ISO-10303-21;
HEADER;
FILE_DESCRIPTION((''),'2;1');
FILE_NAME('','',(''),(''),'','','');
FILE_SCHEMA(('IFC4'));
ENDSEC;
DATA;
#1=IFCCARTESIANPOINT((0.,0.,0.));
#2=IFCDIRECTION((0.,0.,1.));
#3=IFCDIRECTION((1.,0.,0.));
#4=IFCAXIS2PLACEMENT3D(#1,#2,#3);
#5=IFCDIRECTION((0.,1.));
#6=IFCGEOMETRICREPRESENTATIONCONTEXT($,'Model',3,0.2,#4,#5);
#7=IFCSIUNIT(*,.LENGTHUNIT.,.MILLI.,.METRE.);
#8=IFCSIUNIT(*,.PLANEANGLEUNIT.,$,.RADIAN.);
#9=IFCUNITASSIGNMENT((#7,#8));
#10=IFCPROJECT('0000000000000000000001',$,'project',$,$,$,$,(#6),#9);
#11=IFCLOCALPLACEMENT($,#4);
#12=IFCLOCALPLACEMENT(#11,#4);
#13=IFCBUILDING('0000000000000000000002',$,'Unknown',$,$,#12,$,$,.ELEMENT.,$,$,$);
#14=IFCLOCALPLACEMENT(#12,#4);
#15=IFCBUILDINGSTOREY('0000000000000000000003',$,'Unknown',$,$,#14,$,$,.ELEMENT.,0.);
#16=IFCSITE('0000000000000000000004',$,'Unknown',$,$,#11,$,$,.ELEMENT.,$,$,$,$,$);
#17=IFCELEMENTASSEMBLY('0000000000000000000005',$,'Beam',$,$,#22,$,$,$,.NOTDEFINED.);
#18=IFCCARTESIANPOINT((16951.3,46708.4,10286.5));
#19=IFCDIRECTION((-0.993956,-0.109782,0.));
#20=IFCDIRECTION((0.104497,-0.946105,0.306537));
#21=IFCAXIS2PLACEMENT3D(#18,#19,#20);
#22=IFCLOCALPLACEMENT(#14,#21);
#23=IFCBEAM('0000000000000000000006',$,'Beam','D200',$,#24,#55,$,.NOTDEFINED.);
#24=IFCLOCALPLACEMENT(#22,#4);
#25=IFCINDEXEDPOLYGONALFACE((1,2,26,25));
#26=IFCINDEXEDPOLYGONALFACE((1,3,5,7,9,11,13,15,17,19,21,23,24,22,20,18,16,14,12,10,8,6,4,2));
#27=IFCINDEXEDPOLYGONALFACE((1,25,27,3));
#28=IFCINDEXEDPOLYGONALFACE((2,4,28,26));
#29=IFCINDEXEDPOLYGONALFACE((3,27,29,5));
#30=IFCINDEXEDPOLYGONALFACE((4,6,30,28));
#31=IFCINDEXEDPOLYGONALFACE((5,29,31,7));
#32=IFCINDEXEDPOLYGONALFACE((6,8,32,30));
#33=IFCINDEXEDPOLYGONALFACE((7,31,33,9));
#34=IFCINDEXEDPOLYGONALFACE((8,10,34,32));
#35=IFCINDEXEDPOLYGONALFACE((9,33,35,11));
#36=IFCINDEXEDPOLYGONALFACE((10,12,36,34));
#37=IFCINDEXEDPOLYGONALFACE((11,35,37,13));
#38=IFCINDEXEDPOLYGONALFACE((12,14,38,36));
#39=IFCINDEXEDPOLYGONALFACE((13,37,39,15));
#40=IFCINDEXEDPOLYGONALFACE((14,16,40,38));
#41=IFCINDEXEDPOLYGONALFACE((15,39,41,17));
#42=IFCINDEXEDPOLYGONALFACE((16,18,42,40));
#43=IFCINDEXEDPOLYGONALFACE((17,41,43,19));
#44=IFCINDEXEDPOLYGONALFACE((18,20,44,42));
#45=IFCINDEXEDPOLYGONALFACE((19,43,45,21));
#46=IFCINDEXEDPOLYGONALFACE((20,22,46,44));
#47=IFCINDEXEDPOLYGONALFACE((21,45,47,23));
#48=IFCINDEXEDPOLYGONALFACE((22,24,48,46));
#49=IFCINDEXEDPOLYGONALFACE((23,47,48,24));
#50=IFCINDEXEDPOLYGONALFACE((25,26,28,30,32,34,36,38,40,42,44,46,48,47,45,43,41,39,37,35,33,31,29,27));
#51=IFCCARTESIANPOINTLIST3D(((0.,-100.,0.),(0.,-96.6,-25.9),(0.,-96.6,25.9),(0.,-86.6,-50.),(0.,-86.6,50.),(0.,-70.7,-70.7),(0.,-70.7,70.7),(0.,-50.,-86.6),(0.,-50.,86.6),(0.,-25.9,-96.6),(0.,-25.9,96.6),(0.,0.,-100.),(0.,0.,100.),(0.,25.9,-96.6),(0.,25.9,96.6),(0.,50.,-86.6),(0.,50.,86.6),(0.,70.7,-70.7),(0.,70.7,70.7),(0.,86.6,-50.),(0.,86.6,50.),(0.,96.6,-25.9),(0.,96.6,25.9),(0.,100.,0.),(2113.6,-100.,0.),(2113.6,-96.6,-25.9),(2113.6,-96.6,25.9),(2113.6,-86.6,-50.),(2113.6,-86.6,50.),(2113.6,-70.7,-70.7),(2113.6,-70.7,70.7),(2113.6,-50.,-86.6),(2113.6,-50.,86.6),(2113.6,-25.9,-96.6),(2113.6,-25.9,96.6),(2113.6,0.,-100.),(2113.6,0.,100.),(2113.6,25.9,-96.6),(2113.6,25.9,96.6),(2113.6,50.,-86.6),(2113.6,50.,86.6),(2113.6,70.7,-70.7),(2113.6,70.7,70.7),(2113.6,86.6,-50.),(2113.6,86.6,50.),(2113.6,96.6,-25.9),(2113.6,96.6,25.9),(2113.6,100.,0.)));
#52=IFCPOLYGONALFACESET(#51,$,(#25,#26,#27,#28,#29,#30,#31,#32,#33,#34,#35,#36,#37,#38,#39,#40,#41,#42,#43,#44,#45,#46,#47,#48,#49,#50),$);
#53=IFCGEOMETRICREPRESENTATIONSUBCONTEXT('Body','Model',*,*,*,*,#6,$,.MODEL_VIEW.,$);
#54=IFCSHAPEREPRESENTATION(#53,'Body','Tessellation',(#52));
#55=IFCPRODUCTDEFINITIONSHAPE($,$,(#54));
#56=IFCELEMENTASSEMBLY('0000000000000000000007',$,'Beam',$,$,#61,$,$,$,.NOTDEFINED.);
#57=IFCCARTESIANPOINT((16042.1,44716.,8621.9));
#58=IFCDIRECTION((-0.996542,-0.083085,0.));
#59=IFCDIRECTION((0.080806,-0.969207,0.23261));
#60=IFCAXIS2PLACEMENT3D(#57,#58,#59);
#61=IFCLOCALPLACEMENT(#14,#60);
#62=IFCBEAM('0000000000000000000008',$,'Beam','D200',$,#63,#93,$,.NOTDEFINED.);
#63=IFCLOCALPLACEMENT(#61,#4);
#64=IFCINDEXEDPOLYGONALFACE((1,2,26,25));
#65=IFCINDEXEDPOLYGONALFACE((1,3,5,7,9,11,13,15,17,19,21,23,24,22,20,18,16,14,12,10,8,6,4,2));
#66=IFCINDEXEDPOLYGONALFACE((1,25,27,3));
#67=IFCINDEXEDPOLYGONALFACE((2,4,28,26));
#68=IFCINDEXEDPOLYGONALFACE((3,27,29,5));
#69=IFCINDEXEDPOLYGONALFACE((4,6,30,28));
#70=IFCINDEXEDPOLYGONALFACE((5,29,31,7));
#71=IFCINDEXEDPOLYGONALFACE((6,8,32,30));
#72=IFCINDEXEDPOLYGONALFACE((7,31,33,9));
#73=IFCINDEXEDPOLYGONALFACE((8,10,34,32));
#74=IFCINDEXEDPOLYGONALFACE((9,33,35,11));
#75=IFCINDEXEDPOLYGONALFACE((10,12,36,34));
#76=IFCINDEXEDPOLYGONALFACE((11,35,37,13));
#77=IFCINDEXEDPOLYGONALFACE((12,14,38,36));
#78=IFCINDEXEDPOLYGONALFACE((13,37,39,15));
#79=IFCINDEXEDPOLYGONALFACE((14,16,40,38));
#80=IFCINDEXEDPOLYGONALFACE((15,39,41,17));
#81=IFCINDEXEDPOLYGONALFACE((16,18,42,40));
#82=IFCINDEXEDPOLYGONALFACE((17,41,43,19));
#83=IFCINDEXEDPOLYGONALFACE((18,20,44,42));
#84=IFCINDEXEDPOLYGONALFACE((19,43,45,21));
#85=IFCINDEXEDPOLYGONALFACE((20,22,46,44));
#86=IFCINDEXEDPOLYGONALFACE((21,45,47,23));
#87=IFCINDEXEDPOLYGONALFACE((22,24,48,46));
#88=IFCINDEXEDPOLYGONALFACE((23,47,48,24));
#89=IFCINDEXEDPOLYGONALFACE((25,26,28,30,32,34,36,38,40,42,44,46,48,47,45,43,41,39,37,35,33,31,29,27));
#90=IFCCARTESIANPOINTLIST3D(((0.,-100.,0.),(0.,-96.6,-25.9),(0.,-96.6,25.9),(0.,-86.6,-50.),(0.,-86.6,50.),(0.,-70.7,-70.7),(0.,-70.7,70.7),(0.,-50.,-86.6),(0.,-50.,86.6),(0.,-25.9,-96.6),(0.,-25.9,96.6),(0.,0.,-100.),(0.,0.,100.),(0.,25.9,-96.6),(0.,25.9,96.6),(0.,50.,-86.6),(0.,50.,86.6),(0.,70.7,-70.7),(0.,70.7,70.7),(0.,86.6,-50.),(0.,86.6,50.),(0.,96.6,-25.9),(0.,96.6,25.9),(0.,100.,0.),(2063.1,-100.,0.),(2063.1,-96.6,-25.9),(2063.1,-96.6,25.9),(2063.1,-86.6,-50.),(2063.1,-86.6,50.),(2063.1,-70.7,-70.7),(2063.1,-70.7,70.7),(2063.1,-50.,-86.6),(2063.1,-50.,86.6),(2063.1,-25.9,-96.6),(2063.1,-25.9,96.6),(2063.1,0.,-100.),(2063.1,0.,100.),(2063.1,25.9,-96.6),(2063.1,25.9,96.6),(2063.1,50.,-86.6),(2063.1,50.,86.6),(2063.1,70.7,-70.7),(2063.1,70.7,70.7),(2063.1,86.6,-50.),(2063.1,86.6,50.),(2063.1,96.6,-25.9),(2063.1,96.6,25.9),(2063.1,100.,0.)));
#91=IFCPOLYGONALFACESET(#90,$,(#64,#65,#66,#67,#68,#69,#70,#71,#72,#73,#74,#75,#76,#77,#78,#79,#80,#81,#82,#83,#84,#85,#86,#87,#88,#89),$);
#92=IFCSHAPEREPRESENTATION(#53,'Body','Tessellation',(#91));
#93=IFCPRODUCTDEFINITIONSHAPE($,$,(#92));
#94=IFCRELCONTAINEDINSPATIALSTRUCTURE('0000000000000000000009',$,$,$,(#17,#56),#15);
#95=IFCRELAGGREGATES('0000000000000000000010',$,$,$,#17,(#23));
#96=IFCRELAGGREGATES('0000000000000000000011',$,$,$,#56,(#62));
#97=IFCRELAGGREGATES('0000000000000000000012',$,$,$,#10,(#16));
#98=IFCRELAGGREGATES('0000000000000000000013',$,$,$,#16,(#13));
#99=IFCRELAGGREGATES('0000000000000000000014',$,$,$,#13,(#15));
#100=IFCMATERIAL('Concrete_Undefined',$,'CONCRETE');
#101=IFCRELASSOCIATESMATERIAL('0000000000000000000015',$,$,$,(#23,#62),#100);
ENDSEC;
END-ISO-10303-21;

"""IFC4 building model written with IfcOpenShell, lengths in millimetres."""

from ifc_helpers import new_model, si_unit, direction, frame, origin_with_axes, place, context, subcontext, project, spatial, line, indexed_curve, outline, extrude, material, element, aggregate, save


model = new_model("IFC4")

# Units and contexts
model_context = context("Model", 3, precision=0.2, world=origin_with_axes(), true_north=direction((0.0, 1.0)))
body_context = subcontext(model_context, "Body", "Model", "MODEL_VIEW")
ifc_project = project(units=[si_unit("LENGTHUNIT", "METRE", prefix="MILLI"), si_unit("PLANEANGLEUNIT", "RADIAN")], contexts=[model_context])

# Site, building, storey
site_placement = place(None, origin_with_axes())
site = spatial("IfcSite", under=ifc_project, at=site_placement, Name="Unknown", CompositionType="ELEMENT")
building_placement = place(site_placement, origin_with_axes())
building = spatial("IfcBuilding", under=site, at=building_placement, Name="Unknown", CompositionType="ELEMENT")
storey_placement = place(building_placement, origin_with_axes())
storey = spatial("IfcBuildingStorey", under=building, at=storey_placement, Name="Unknown", CompositionType="ELEMENT", Elevation=0.0)

# Shared definitions
ifc_material = material(Name="Concrete_Undefined", Category="CONCRETE")

# Element assembly, beam
assembly_1_placement = place(storey_placement, frame((16951.3, 46708.4, 10286.5), z_axis=(-0.993956, -0.109782, 0.0), x_axis=(0.104497, -0.946105, 0.306537)))
assembly_1 = element("IfcElementAssembly", 1, at=assembly_1_placement, inside=storey, Name="Beam", PredefinedType="NOTDEFINED")
beam_1_placement = place(assembly_1_placement, origin_with_axes())
beam_1 = element("IfcBeam", 2, at=beam_1_placement, material=ifc_material, Name="Beam", Description="D200", PredefinedType="NOTDEFINED", context=body_context, shape_type="SolidModel", body=[
    extrude(outline(indexed_curve([(100.0, 0.0), (96.6, 25.9), (86.6, 50.0), (70.7, 70.7), (50.0, 86.6), (25.9, 96.6), (0.0, 100.0), (-25.9, 96.6), (-50.0, 86.6), (-70.7, 70.7), (-86.6, 50.0), (-96.6, 25.9), (-100.0, 0.0), (-96.6, -25.9), (-86.6, -50.0), (-70.7, -70.7), (-50.0, -86.6), (-25.9, -96.6), (0.0, -100.0), (25.9, -96.6), (50.0, -86.6), (70.7, -70.7), (86.6, -50.0), (96.6, -25.9)], segments=[line(1, 2, 3, 4, 5, 6, 7, 8, 9, 10, 11, 12, 13, 14, 15, 16, 17, 18, 19, 20, 21, 22, 23, 24, 1)])), frame((0.0, 0.0, 0.0), z_axis=(-1.0, 0.0, 0.0), x_axis=(0.0, 0.0, 1.0)), (0.0, 0.0, -1.0), 2113.6),
])
aggregate(assembly_1, [beam_1])

# Element assembly, beam
assembly_2_placement = place(storey_placement, frame((16042.1, 44716.0, 8621.9), z_axis=(-0.996542, -0.083085, 0.0), x_axis=(0.080806, -0.969207, 0.23261)))
assembly_2 = element("IfcElementAssembly", 3, at=assembly_2_placement, inside=storey, Name="Beam", PredefinedType="NOTDEFINED")
beam_2_placement = place(assembly_2_placement, origin_with_axes())
beam_2 = element("IfcBeam", 4, at=beam_2_placement, material=ifc_material, Name="Beam", Description="D200", PredefinedType="NOTDEFINED", context=body_context, shape_type="SolidModel", body=[
    extrude(outline(indexed_curve([(100.0, 0.0), (96.6, 25.9), (86.6, 50.0), (70.7, 70.7), (50.0, 86.6), (25.9, 96.6), (0.0, 100.0), (-25.9, 96.6), (-50.0, 86.6), (-70.7, 70.7), (-86.6, 50.0), (-96.6, 25.9), (-100.0, 0.0), (-96.6, -25.9), (-86.6, -50.0), (-70.7, -70.7), (-50.0, -86.6), (-25.9, -96.6), (0.0, -100.0), (25.9, -96.6), (50.0, -86.6), (70.7, -70.7), (86.6, -50.0), (96.6, -25.9)], segments=[line(1, 2, 3, 4, 5, 6, 7, 8, 9, 10, 11, 12, 13, 14, 15, 16, 17, 18, 19, 20, 21, 22, 23, 24, 1)])), frame((0.0, 0.0, 0.0), z_axis=(-1.0, 0.0, 0.0), x_axis=(0.0, 0.0, 1.0)), (0.0, 0.0, -1.0), 2063.1),
])
aggregate(assembly_2, [beam_2])

save(model, "model.ifc")
